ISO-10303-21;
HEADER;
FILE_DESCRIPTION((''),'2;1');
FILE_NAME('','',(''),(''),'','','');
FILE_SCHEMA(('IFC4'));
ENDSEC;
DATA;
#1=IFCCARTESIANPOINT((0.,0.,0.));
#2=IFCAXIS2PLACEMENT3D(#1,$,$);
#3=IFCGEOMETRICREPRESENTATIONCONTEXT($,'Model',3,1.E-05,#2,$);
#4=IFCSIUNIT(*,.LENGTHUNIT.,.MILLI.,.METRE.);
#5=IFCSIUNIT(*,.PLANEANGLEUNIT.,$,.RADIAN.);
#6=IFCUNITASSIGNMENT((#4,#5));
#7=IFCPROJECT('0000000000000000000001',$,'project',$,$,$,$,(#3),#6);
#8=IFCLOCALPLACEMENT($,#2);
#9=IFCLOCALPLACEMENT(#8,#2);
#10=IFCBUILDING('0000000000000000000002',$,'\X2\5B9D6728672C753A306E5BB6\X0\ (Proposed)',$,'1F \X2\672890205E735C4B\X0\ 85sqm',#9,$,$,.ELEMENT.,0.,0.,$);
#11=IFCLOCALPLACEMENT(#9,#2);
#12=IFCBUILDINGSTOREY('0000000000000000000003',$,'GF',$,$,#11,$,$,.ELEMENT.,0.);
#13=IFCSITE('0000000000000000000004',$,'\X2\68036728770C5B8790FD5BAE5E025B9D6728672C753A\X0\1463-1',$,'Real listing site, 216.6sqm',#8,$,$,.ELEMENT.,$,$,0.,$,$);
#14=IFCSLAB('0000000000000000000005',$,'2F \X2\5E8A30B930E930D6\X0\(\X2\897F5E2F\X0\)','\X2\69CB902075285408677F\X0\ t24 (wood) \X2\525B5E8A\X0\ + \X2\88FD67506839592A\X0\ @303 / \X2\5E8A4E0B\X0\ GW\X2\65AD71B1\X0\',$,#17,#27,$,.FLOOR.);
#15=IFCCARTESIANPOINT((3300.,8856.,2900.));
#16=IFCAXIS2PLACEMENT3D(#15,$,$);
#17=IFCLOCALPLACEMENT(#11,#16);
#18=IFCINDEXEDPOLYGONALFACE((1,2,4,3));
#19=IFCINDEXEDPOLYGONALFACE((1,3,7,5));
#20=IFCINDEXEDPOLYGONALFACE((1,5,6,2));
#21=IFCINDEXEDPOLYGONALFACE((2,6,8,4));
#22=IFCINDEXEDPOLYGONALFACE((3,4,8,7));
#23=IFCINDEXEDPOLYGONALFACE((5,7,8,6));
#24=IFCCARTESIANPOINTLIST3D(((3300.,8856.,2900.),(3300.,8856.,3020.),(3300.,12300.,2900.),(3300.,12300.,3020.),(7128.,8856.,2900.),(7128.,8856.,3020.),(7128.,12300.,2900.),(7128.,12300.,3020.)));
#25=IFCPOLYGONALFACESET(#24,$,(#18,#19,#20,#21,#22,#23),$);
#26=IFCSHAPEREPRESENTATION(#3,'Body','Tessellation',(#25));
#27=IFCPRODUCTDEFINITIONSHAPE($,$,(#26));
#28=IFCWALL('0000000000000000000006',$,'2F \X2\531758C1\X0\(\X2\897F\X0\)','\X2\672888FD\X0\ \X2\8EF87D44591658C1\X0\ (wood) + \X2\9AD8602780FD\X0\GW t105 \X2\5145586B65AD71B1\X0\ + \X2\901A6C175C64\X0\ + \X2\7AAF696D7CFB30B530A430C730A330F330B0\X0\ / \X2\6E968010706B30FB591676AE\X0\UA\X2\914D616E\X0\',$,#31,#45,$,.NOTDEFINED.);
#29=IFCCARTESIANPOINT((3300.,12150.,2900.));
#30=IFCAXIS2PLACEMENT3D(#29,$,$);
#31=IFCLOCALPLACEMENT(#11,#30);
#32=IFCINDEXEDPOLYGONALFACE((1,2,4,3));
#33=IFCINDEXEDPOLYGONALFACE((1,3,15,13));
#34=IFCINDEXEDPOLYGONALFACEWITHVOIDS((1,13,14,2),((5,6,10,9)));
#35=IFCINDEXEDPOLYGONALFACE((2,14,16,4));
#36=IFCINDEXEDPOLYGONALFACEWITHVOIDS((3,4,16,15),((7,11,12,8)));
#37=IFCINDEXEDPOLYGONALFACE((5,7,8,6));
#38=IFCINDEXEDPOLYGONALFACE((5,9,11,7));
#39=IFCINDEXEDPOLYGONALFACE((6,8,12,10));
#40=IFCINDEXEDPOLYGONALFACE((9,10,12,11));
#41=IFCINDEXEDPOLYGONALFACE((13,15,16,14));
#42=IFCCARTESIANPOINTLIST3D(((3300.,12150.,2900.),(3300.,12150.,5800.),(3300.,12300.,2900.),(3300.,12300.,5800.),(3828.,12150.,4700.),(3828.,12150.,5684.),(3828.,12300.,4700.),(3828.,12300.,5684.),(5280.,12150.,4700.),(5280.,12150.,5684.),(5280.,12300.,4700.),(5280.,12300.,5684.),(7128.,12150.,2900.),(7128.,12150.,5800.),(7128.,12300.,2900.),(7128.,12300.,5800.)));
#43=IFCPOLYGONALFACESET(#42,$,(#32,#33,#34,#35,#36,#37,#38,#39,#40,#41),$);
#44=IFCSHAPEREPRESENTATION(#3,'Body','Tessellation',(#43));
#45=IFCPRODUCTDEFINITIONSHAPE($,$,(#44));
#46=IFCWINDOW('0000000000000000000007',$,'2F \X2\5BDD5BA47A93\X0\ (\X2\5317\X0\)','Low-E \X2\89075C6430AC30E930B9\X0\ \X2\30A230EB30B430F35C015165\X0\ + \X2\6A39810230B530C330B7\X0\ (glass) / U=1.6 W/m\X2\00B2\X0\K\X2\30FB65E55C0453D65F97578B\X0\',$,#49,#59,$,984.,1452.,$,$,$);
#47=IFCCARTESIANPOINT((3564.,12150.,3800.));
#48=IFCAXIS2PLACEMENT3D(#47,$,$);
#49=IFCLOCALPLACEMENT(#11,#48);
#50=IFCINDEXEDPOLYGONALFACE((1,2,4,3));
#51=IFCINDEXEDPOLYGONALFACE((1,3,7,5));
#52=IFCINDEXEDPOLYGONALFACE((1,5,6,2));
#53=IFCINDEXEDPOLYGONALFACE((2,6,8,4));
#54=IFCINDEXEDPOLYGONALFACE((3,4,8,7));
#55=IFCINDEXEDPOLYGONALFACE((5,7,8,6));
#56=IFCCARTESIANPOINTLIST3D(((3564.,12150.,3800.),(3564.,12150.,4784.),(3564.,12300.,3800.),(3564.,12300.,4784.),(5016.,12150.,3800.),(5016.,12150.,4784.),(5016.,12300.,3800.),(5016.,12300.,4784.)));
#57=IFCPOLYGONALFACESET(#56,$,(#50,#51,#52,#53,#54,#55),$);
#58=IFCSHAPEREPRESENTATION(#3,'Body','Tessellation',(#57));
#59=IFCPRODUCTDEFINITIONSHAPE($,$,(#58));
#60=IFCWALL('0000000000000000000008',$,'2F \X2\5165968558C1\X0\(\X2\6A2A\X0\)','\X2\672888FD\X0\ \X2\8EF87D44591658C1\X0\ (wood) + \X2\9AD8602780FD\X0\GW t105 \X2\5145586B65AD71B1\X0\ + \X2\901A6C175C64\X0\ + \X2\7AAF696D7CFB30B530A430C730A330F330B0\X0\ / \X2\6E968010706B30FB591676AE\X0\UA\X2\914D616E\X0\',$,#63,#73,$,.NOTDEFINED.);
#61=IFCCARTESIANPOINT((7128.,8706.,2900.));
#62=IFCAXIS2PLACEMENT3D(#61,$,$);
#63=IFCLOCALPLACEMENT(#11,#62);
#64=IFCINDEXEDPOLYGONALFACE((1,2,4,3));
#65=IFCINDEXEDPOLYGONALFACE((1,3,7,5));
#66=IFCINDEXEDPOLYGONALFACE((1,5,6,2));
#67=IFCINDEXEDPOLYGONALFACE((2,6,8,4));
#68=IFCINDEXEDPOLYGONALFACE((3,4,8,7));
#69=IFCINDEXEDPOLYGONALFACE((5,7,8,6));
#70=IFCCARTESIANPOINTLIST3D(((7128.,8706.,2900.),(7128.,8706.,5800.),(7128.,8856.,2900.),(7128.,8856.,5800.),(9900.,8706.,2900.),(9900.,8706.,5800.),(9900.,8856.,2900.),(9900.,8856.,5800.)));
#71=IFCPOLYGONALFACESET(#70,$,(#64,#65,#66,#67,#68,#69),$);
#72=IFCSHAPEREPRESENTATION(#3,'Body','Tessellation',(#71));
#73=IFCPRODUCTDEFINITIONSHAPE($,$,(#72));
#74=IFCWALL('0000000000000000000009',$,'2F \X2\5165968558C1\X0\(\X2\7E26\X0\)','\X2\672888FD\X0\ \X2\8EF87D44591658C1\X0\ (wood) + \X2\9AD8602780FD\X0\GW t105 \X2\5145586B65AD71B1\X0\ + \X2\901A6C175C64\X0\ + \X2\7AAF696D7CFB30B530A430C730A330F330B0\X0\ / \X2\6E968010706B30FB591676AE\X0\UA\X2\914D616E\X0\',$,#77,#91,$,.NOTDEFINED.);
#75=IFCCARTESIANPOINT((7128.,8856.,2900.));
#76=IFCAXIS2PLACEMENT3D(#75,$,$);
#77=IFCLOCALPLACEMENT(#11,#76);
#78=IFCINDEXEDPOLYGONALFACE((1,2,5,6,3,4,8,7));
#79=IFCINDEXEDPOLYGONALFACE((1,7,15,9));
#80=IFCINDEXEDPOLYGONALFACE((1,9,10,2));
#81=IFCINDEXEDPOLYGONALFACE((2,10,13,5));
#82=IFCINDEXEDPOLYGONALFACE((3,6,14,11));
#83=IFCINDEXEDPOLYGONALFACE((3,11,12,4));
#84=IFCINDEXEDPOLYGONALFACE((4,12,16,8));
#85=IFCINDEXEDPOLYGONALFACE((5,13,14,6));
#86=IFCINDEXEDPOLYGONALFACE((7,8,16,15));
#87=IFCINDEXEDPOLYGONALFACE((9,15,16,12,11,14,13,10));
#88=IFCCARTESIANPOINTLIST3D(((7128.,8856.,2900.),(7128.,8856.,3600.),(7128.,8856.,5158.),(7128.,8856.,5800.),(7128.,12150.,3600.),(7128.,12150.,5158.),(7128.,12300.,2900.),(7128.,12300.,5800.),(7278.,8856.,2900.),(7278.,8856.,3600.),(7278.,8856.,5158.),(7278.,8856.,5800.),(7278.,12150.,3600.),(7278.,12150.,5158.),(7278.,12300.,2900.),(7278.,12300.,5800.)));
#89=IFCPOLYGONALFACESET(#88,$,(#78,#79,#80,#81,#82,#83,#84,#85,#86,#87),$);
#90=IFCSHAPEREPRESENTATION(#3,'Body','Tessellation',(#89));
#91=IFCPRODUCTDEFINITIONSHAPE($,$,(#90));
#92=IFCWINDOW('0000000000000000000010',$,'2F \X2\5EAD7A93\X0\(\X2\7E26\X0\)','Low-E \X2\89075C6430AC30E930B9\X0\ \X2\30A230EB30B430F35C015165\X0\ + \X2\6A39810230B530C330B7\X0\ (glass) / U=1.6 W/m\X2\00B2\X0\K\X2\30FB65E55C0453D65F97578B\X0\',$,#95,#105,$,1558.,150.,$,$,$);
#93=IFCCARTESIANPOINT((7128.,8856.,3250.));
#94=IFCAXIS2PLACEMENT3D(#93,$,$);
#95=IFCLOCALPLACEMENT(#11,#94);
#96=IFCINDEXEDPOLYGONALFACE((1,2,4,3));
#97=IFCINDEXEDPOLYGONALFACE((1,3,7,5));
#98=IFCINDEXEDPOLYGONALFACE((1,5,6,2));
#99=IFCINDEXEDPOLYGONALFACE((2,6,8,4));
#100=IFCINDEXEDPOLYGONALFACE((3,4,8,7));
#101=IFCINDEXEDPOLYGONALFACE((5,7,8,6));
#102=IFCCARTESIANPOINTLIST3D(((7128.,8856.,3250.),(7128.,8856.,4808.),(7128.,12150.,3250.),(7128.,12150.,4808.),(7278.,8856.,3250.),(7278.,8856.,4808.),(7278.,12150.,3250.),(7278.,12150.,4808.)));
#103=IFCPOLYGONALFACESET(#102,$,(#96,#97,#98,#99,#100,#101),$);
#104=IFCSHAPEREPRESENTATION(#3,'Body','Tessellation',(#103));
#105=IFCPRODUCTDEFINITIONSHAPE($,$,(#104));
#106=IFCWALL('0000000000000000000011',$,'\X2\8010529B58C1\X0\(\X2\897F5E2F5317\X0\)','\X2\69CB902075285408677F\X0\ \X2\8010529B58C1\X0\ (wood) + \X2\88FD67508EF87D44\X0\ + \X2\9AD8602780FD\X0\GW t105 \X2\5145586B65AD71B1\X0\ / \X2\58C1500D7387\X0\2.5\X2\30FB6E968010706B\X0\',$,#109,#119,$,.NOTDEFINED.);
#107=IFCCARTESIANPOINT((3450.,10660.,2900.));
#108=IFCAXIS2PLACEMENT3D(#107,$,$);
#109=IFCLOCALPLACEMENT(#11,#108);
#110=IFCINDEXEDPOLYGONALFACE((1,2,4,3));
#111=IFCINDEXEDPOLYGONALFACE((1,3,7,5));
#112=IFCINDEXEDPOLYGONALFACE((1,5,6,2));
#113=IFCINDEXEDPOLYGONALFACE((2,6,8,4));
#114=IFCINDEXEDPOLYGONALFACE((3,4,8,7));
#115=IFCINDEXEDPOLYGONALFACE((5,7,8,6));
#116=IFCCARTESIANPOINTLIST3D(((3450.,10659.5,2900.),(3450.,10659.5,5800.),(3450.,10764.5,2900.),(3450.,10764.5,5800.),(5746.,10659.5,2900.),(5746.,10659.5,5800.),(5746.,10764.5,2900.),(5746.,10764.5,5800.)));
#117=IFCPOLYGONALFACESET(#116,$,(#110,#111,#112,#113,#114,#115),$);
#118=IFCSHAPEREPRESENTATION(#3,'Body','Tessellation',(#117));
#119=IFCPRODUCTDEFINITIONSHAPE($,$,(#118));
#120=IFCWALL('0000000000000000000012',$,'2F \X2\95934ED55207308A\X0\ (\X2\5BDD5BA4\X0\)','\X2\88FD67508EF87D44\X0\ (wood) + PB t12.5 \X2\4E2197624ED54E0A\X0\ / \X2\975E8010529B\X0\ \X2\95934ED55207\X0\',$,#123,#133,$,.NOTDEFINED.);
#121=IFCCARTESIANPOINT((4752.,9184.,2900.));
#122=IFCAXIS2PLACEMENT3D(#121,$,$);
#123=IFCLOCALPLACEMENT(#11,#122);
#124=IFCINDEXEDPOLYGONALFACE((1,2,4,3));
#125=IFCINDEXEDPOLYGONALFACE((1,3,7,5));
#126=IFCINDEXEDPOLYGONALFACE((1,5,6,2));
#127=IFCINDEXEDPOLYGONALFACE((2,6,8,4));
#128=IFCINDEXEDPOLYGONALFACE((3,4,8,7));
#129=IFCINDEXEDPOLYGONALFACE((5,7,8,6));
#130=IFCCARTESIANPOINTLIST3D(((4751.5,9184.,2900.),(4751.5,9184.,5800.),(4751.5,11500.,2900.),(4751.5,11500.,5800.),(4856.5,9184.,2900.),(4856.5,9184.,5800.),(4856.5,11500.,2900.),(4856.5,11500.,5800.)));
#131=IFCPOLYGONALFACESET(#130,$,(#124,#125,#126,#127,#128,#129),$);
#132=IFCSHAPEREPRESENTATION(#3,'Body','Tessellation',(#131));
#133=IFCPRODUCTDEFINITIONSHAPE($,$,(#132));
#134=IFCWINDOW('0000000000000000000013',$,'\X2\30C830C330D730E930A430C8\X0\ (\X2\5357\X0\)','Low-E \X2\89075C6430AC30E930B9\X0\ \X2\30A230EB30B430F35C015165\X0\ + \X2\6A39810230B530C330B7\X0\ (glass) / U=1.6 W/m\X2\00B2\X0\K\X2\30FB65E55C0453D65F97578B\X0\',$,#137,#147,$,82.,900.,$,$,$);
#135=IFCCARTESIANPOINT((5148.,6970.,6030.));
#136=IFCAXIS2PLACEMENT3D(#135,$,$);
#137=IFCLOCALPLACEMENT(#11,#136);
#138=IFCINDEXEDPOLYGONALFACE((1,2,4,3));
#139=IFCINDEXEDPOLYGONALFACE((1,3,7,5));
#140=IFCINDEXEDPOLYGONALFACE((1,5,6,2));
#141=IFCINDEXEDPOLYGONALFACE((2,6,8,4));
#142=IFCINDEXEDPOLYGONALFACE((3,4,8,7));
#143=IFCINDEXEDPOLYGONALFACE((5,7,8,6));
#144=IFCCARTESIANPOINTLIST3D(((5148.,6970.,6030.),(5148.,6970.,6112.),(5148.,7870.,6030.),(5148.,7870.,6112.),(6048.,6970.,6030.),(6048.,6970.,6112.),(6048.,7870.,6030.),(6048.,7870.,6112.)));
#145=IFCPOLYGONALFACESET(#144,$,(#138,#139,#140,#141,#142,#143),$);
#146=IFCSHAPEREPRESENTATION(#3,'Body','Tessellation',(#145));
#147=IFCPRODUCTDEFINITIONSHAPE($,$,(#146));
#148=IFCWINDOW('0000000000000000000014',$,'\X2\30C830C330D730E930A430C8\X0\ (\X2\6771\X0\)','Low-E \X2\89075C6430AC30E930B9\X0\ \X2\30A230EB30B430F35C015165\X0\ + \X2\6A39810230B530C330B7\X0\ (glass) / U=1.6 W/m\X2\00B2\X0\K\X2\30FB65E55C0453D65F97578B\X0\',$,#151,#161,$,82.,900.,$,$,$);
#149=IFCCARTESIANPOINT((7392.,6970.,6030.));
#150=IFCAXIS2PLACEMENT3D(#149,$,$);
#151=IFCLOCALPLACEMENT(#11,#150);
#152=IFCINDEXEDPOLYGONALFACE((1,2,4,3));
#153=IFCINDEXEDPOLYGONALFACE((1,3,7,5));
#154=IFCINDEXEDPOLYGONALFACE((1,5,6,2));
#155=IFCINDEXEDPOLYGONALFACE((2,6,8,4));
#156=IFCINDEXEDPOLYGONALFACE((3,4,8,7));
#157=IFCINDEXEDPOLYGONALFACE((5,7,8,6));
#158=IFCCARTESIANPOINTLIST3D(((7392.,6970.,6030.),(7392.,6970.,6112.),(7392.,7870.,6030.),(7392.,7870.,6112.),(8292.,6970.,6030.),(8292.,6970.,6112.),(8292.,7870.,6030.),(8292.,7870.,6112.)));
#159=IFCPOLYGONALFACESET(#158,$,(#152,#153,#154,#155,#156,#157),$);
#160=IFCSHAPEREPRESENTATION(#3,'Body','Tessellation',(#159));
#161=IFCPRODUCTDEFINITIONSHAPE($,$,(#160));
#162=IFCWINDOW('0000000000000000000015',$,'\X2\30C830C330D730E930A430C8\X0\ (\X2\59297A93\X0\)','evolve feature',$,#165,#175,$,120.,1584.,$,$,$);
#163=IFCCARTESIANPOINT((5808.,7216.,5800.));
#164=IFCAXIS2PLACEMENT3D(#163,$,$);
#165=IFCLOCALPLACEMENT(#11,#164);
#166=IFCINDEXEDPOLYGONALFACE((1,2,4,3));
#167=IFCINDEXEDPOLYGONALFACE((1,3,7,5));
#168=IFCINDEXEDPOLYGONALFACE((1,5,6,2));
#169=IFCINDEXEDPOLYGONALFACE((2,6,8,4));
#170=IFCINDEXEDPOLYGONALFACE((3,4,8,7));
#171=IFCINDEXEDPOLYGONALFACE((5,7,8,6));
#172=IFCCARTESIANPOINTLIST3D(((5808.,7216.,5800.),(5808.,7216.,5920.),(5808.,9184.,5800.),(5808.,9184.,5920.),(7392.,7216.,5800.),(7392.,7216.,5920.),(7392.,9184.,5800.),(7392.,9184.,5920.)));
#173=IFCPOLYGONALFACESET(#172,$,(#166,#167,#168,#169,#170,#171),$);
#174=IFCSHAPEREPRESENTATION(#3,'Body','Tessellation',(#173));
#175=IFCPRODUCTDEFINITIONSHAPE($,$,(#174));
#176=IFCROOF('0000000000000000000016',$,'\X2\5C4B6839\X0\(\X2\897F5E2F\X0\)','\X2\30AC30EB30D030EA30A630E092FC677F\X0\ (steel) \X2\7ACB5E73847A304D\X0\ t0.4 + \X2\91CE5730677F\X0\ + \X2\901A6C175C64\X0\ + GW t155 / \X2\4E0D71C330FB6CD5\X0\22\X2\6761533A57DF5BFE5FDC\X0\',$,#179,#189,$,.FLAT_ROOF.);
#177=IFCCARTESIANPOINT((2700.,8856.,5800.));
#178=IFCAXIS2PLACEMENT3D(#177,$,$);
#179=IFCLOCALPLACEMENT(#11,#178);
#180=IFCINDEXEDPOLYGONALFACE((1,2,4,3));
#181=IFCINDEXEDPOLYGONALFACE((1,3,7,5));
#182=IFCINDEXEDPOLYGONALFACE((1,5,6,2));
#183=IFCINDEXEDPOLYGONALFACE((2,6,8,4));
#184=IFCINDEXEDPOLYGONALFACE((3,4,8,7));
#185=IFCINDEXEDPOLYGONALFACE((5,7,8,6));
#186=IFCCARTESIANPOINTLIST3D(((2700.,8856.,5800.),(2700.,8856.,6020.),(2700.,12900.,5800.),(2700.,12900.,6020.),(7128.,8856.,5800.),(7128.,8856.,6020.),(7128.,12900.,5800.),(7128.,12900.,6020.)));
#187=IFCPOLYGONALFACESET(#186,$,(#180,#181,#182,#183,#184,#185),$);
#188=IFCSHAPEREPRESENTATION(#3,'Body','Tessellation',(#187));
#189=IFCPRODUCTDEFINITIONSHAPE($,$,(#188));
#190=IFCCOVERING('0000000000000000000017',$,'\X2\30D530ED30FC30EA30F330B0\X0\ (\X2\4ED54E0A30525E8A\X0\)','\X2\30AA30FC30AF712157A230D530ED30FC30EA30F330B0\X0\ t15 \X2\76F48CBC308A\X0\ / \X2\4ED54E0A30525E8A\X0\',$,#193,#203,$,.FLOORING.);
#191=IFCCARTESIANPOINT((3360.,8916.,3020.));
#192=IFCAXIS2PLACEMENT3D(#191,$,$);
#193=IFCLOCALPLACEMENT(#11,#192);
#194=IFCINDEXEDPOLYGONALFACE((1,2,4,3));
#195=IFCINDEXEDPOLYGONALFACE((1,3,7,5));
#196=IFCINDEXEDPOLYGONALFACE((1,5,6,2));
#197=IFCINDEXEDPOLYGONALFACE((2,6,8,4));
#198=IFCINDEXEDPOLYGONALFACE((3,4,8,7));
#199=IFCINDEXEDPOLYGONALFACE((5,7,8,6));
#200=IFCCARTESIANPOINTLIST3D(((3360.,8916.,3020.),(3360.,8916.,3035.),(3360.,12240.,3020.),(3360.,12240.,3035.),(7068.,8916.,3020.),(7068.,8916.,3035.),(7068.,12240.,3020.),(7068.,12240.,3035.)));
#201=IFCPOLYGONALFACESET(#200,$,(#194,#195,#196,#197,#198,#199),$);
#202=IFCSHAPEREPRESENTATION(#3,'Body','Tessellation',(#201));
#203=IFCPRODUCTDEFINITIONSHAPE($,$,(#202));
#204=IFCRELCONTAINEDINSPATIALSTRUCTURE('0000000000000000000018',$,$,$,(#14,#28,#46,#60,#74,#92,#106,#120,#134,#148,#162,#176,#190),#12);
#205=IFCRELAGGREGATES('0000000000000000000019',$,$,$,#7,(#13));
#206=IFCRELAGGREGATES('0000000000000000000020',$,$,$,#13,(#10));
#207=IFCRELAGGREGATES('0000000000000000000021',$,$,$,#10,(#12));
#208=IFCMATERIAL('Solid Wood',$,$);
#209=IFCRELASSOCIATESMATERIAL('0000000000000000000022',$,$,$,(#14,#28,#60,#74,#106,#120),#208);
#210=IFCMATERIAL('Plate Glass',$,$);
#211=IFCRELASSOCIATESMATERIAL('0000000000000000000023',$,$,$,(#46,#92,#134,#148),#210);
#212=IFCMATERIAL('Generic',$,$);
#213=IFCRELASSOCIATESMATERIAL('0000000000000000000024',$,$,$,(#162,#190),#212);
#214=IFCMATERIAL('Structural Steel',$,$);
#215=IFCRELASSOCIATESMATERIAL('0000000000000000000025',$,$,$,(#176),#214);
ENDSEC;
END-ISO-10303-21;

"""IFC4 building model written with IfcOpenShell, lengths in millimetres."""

from ifc_helpers import new_model, si_unit, frame, frame_2d, origin, place, context, project, spatial, rectangle, extrude, material, element, fill, save


model = new_model("IFC4")

# Units and contexts
model_context = context("Model", 3, precision=1e-05, world=origin())
ifc_project = project(units=[si_unit("LENGTHUNIT", "METRE", prefix="MILLI"), si_unit("PLANEANGLEUNIT", "RADIAN")], contexts=[model_context])

# Site, building, storey
site_placement = place(None, origin())
site = spatial("IfcSite", under=ifc_project, at=site_placement, Name="栃木県宇都宮市宝木本町1463-1", ObjectType="Real listing site, 216.6sqm", CompositionType="ELEMENT", RefElevation=0.0)
building_placement = place(site_placement, origin())
building = spatial("IfcBuilding", under=site, at=building_placement, Name="宝木本町の家 (Proposed)", ObjectType="1F 木造平屋 85sqm", CompositionType="ELEMENT", ElevationOfRefHeight=0.0, ElevationOfTerrain=0.0)
storey_placement = place(building_placement, origin())
storey = spatial("IfcBuildingStorey", under=building, at=storey_placement, Name="GF", CompositionType="ELEMENT", Elevation=0.0)

# Slab
ifc_material_1 = material(Name="Solid Wood")
slab_placement = place(storey_placement, frame((3300.0, 8856.0, 2900.0)))
element("IfcSlab", 1, at=slab_placement, inside=storey, material=ifc_material_1, Name="2F 床スラブ(西帯)", Description="構造用合板 t24 (wood) 剛床 + 製材根太 @303 / 床下 GW断熱", PredefinedType="FLOOR", context=model_context, shape_type="SweptSolid", body=[
    extrude(rectangle(XDim=3828.0, YDim=3444.0, at=frame_2d((1914.0, 1722.0))), frame((3300.0, 8856.0, 2900.0)), (0.0, 0.0, 1.0), 120.0),
])

# Wall, opening, window
wall_1_placement = place(storey_placement, frame((3300.0, 12150.0, 2900.0)))
wall_1 = element("IfcWall", 2, at=wall_1_placement, inside=storey, material=ifc_material_1, Name="2F 北壁(西)", Description="木製 軸組外壁 (wood) + 高性能GW t105 充填断熱 + 通気層 + 窯業系サイディング / 準耐火・外皮UA配慮", PredefinedType="NOTDEFINED", context=model_context, shape_type="SweptSolid", body=[
    extrude(rectangle(XDim=3828.0, YDim=150.0, at=frame_2d((1914.0, 75.0))), frame((3300.0, 12150.0, 2900.0)), (0.0, 0.0, 1.0), 2900.0),
])
opening_1_placement = place(storey_placement, frame((3564.0, 12150.0, 3800.0)))
opening_1 = element("IfcOpeningElement", 3, at=opening_1_placement, cuts=wall_1, PredefinedType="NOTDEFINED", context=model_context, shape_type="SweptSolid", body=[
    extrude(rectangle(XDim=1452.0, YDim=150.0, at=frame_2d((726.0, 75.0))), frame((3564.0, 12150.0, 3800.0)), (0.0, 0.0, 1.0), 984.0),
])
ifc_material_2 = material(Name="Plate Glass")
window_1_placement = place(storey_placement, frame((3564.0, 12150.0, 3800.0)))
window_1 = element("IfcWindow", 4, at=window_1_placement, inside=storey, material=ifc_material_2, Name="2F 寝室窓 (北)", Description="Low-E 複層ガラス アルゴン封入 + 樹脂サッシ (glass) / U=1.6 W/m²K・日射取得型", OverallHeight=984.0, OverallWidth=1452.0, context=model_context, shape_type="SweptSolid", body=[
    extrude(rectangle(XDim=1452.0, YDim=150.0, at=frame_2d((726.0, 75.0))), frame((3564.0, 12150.0, 3800.0)), (0.0, 0.0, 1.0), 984.0),
])
fill(opening_1, window_1)

# Wall
wall_2_placement = place(storey_placement, frame((7128.0, 8706.0, 2900.0)))
element("IfcWall", 5, at=wall_2_placement, inside=storey, material=ifc_material_1, Name="2F 入隅壁(横)", Description="木製 軸組外壁 (wood) + 高性能GW t105 充填断熱 + 通気層 + 窯業系サイディング / 準耐火・外皮UA配慮", PredefinedType="NOTDEFINED", context=model_context, shape_type="SweptSolid", body=[
    extrude(rectangle(XDim=2772.0, YDim=150.0, at=frame_2d((1386.0, 75.0))), frame((7128.0, 8706.0, 2900.0)), (0.0, 0.0, 1.0), 2900.0),
])

# Wall, opening, window
wall_3_placement = place(storey_placement, frame((7128.0, 8856.0, 2900.0)))
wall_3 = element("IfcWall", 6, at=wall_3_placement, inside=storey, material=ifc_material_1, Name="2F 入隅壁(縦)", Description="木製 軸組外壁 (wood) + 高性能GW t105 充填断熱 + 通気層 + 窯業系サイディング / 準耐火・外皮UA配慮", PredefinedType="NOTDEFINED", context=model_context, shape_type="SweptSolid", body=[
    extrude(rectangle(XDim=150.0, YDim=3444.0, at=frame_2d((75.0, 1722.0))), frame((7128.0, 8856.0, 2900.0)), (0.0, 0.0, 1.0), 2900.0),
])
opening_2_placement = place(storey_placement, frame((7128.0, 8856.0, 3250.0)))
opening_2 = element("IfcOpeningElement", 7, at=opening_2_placement, cuts=wall_3, PredefinedType="NOTDEFINED", context=model_context, shape_type="SweptSolid", body=[
    extrude(rectangle(XDim=150.0, YDim=3294.0, at=frame_2d((75.0, 1647.0))), frame((7128.0, 8856.0, 3250.0)), (0.0, 0.0, 1.0), 1558.0),
])
window_2_placement = place(storey_placement, frame((7128.0, 8856.0, 3250.0)))
window_2 = element("IfcWindow", 8, at=window_2_placement, inside=storey, material=ifc_material_2, Name="2F 庭窓(縦)", Description="Low-E 複層ガラス アルゴン封入 + 樹脂サッシ (glass) / U=1.6 W/m²K・日射取得型", OverallHeight=1558.0, OverallWidth=150.0, context=model_context, shape_type="SweptSolid", body=[
    extrude(rectangle(XDim=150.0, YDim=3294.0, at=frame_2d((75.0, 1647.0))), frame((7128.0, 8856.0, 3250.0)), (0.0, 0.0, 1.0), 1558.0),
])
fill(opening_2, window_2)

# Walls
wall_4_placement = place(storey_placement, frame((3450.0, 10660.0, 2900.0)))
element("IfcWall", 9, at=wall_4_placement, inside=storey, material=ifc_material_1, Name="耐力壁(西帯北)", Description="構造用合板 耐力壁 (wood) + 製材軸組 + 高性能GW t105 充填断熱 / 壁倍率2.5・準耐火", PredefinedType="NOTDEFINED", context=model_context, shape_type="SweptSolid", body=[
    extrude(rectangle(XDim=2296.0, YDim=105.0, at=frame_2d((1148.0, 52.0))), frame((3450.0, 10660.0, 2900.0)), (0.0, 0.0, 1.0), 2900.0),
])
wall_5_placement = place(storey_placement, frame((4752.0, 9184.0, 2900.0)))
element("IfcWall", 10, at=wall_5_placement, inside=storey, material=ifc_material_1, Name="2F 間仕切り (寝室)", Description="製材軸組 (wood) + PB t12.5 両面仕上 / 非耐力 間仕切", PredefinedType="NOTDEFINED", context=model_context, shape_type="SweptSolid", body=[
    extrude(rectangle(XDim=105.0, YDim=2316.0, at=frame_2d((52.0, 1158.0))), frame((4752.0, 9184.0, 2900.0)), (0.0, 0.0, 1.0), 2900.0),
])

# Windows
window_3_placement = place(storey_placement, frame((5148.0, 6970.0, 6030.0)))
element("IfcWindow", 11, at=window_3_placement, inside=storey, material=ifc_material_2, Name="トップライト (南)", Description="Low-E 複層ガラス アルゴン封入 + 樹脂サッシ (glass) / U=1.6 W/m²K・日射取得型", OverallHeight=82.0, OverallWidth=900.0, context=model_context, shape_type="SweptSolid", body=[
    extrude(rectangle(XDim=900.0, YDim=900.0, at=frame_2d((450.0, 450.0))), frame((5148.0, 6970.0, 6030.0)), (0.0, 0.0, 1.0), 82.0),
])
window_4_placement = place(storey_placement, frame((7392.0, 6970.0, 6030.0)))
element("IfcWindow", 12, at=window_4_placement, inside=storey, material=ifc_material_2, Name="トップライト (東)", Description="Low-E 複層ガラス アルゴン封入 + 樹脂サッシ (glass) / U=1.6 W/m²K・日射取得型", OverallHeight=82.0, OverallWidth=900.0, context=model_context, shape_type="SweptSolid", body=[
    extrude(rectangle(XDim=900.0, YDim=900.0, at=frame_2d((450.0, 450.0))), frame((7392.0, 6970.0, 6030.0)), (0.0, 0.0, 1.0), 82.0),
])
ifc_material_3 = material(Name="Generic")
window_5_placement = place(storey_placement, frame((5808.0, 7216.0, 5800.0)))
element("IfcWindow", 13, at=window_5_placement, inside=storey, material=ifc_material_3, Name="トップライト (天窓)", Description="evolve feature", OverallHeight=120.0, OverallWidth=1584.0, context=model_context, shape_type="SweptSolid", body=[
    extrude(rectangle(XDim=1584.0, YDim=1968.0, at=frame_2d((792.0, 984.0))), frame((5808.0, 7216.0, 5800.0)), (0.0, 0.0, 1.0), 120.0),
])

# Roof
ifc_material_4 = material(Name="Structural Steel")
for number, where, name in (
    (14, (2700.0, 8856.0, 5800.0), "屋根(西帯)"),
):
    element("IfcRoof", number, at=place(storey_placement, frame(where)), inside=storey, material=ifc_material_4, Name=name, Description="ガルバリウム鋼板 (steel) 立平葺き t0.4 + 野地板 + 通気層 + GW t155 / 不燃・法22条区域対応", PredefinedType="FLAT_ROOF", context=model_context, shape_type="SweptSolid", body=[
        extrude(rectangle(XDim=4428.0, YDim=4044.0, at=frame_2d((2214.0, 2022.0))), frame((2700.0, 8856.0, 5800.0)), (0.0, 0.0, 1.0), 220.0),
    ])

# Covering
covering_placement = place(storey_placement, frame((3360.0, 8916.0, 3020.0)))
element("IfcCovering", 15, at=covering_placement, inside=storey, material=ifc_material_3, Name="フローリング (仕上げ床)", Description="オーク無垢フローリング t15 直貼り / 仕上げ床", PredefinedType="FLOORING", context=model_context, shape_type="SweptSolid", body=[
    extrude(rectangle(XDim=3708.0, YDim=3324.0, at=frame_2d((1854.0, 1662.0))), frame((3360.0, 8916.0, 3020.0)), (0.0, 0.0, 1.0), 15.0),
])

save(model, "model.ifc")
